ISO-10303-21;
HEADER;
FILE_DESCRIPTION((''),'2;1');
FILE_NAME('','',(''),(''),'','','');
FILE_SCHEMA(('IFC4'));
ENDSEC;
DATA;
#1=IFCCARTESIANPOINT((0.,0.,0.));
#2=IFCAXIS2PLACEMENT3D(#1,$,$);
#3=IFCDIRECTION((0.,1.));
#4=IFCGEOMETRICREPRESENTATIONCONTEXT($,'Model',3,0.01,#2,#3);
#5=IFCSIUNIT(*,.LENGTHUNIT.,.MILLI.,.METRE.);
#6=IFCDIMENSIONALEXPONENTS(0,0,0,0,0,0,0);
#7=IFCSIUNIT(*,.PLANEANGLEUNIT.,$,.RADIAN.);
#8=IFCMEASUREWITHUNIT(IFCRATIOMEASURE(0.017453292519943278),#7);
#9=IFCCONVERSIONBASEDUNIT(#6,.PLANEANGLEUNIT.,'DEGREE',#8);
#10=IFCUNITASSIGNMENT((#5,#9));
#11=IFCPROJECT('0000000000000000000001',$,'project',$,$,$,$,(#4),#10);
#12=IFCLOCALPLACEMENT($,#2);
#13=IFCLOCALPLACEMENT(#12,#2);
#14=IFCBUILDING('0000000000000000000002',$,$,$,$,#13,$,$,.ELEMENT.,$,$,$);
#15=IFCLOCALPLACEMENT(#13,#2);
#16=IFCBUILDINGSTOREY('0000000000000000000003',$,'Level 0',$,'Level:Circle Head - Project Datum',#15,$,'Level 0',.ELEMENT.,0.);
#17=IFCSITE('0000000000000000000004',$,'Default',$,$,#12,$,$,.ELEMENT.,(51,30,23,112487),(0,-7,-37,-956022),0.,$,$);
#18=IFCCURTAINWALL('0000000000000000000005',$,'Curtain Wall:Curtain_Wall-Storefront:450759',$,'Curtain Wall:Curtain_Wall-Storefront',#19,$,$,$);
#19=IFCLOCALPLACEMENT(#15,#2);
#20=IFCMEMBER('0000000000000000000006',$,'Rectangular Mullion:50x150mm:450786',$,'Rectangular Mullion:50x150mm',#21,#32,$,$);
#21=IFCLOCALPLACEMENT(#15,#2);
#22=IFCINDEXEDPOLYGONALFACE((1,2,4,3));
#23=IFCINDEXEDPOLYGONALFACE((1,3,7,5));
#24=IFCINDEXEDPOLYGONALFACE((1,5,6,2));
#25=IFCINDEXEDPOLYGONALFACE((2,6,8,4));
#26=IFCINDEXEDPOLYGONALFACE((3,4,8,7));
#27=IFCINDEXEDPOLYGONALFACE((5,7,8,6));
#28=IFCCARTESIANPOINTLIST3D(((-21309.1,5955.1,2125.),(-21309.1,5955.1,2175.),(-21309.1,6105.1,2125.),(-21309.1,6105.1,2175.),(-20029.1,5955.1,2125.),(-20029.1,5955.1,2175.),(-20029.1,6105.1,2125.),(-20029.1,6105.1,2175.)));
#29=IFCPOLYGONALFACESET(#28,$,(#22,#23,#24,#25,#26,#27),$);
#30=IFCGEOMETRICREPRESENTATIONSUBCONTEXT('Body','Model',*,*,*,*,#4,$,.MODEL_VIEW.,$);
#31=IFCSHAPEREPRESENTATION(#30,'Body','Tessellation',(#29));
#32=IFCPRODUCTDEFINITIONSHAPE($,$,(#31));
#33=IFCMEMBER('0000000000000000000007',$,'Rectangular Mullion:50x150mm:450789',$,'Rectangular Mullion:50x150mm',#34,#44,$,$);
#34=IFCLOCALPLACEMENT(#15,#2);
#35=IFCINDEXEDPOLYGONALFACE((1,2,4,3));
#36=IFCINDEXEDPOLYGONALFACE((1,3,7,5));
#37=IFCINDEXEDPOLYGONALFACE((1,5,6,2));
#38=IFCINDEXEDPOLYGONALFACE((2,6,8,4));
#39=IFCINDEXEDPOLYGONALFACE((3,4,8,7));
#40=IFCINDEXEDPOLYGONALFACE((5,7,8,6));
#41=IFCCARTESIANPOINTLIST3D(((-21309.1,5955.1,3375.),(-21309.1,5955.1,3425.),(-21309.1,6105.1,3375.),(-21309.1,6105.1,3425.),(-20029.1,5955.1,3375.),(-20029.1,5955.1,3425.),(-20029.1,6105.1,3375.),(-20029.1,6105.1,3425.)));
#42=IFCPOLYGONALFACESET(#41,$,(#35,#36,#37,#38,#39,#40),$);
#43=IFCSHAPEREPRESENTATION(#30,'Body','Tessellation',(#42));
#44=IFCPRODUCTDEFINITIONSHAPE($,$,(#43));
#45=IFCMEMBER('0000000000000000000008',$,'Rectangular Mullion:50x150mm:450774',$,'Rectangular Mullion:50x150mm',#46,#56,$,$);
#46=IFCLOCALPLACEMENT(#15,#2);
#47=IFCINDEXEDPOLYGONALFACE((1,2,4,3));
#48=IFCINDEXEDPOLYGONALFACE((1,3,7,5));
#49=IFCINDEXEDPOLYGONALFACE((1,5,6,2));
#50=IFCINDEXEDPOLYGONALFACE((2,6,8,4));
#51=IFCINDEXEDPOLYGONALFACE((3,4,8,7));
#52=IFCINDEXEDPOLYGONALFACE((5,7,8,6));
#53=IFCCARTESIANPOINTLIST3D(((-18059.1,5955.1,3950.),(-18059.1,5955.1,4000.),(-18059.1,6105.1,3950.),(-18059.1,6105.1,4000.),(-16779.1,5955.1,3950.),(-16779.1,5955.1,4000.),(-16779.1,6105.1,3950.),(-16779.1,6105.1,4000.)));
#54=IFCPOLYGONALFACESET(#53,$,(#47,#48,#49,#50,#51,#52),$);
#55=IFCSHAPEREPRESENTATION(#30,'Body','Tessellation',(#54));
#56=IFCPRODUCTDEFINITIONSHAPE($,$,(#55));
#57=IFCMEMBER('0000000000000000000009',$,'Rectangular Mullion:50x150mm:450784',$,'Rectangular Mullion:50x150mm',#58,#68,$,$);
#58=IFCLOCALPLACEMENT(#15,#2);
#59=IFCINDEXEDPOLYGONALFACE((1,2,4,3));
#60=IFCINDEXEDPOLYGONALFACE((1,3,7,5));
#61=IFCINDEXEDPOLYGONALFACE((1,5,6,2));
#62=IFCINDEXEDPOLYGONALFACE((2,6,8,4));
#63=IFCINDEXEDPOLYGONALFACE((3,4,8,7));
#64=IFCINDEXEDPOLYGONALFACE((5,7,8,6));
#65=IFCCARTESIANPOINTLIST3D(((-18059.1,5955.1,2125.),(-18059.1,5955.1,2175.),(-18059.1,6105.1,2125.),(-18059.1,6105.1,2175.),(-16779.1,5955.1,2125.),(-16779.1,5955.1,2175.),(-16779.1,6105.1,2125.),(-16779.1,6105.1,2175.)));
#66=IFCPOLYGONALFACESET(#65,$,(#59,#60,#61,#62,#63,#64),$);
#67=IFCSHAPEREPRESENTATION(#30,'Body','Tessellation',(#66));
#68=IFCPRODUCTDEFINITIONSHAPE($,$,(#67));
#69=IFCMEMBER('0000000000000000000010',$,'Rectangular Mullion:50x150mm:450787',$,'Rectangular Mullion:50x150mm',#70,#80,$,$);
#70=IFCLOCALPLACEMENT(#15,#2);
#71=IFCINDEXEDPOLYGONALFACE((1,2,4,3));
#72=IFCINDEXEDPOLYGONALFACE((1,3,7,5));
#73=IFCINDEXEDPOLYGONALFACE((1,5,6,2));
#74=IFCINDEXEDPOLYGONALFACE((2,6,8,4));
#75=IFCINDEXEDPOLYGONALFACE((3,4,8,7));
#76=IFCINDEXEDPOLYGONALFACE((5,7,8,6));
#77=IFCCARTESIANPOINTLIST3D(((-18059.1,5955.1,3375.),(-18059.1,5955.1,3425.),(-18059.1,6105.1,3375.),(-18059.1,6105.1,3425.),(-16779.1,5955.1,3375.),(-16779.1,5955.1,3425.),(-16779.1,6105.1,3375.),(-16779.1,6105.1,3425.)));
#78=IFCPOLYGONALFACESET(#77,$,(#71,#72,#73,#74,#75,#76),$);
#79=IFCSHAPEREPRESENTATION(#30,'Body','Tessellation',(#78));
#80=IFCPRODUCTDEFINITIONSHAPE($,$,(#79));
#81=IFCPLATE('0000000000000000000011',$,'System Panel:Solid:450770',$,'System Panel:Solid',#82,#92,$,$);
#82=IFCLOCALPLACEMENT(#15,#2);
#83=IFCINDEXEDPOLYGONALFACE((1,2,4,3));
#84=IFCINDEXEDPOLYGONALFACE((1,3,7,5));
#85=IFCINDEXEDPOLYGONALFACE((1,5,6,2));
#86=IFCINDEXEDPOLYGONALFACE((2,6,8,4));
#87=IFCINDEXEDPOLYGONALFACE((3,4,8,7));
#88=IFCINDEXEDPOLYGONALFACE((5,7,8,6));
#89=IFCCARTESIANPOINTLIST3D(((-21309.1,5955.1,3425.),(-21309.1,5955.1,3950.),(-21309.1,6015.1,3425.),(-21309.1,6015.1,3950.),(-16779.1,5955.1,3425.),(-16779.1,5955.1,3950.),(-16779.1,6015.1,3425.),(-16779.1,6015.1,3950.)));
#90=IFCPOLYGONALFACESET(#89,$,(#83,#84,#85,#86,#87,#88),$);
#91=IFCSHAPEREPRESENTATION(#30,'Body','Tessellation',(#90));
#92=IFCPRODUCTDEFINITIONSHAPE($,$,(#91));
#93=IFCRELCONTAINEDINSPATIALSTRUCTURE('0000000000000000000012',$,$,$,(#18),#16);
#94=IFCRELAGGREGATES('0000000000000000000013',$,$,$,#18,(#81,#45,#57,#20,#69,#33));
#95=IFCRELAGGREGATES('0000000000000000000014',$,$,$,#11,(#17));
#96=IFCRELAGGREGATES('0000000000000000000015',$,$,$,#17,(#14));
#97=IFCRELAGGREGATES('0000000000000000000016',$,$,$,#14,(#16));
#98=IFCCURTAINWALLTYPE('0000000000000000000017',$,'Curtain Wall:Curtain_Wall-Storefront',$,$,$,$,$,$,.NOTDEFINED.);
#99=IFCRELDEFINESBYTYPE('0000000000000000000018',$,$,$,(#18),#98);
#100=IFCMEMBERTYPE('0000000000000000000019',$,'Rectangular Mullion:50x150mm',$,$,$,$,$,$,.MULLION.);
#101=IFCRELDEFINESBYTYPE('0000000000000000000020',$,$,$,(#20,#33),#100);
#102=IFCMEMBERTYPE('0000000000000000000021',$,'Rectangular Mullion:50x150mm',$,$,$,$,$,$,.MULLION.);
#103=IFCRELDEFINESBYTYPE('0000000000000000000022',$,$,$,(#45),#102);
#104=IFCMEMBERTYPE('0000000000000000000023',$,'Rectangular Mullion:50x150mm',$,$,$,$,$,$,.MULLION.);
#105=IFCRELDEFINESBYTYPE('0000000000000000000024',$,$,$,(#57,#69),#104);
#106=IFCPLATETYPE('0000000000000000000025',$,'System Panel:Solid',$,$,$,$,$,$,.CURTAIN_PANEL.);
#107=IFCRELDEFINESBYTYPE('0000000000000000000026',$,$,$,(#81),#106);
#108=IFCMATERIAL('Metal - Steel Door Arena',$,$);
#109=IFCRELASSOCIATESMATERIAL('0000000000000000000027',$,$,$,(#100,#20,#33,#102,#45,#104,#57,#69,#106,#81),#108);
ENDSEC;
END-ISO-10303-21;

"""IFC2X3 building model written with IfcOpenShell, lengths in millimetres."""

from ifc_helpers import new_model, entity, si_unit, converted_unit, direction, frame, frame_2d, origin, origin_2d_with_axis, place, context, subcontext, project, spatial, rectangle, extrude, source, transform, mapped, material, type_object, type_shapes, element, aggregate, save


model = new_model("IFC2X3")

# Units and contexts
model_context = context("Model", 3, precision=0.01, world=origin(), true_north=direction((0.0, 1.0)))
body_context = subcontext(model_context, "Body", "Model", "MODEL_VIEW")
ifc_project = project(units=[si_unit("LENGTHUNIT", "METRE", prefix="MILLI"), converted_unit("PLANEANGLEUNIT", "DEGREE", entity("IfcRatioMeasure", 0.017453292519943278), si_unit("PLANEANGLEUNIT", "RADIAN"), dimensions=[0, 0, 0, 0, 0, 0, 0])], contexts=[model_context])

# Site, building, storey
site_placement = place(None, origin())
site = spatial("IfcSite", under=ifc_project, at=site_placement, Name="Default", CompositionType="ELEMENT", RefLatitude=(51, 30, 23, 112487), RefLongitude=(0, -7, -37, -956022), RefElevation=0.0)
building_placement = place(site_placement, origin())
building = spatial("IfcBuilding", under=site, at=building_placement, CompositionType="ELEMENT")
storey_placement = place(building_placement, origin())
storey = spatial("IfcBuildingStorey", under=building, at=storey_placement, Name="Level 0", ObjectType="Level:Circle Head - Project Datum", LongName="Level 0", CompositionType="ELEMENT", Elevation=0.0)

# Curtain wall, members, plate
curtain_wall_type = type_object("IfcCurtainWallType", Name="Curtain Wall:Curtain_Wall-Storefront", PredefinedType="NOTDEFINED")
curtain_wall_placement = place(storey_placement, origin())
curtain_wall = element("IfcCurtainWall", 1, at=curtain_wall_placement, inside=storey, type_object=curtain_wall_type, Name="Curtain Wall:Curtain_Wall-Storefront:450759", ObjectType="Curtain Wall:Curtain_Wall-Storefront")
ifc_material_1 = material(Name="Metal - Steel Door Arena")
member_type_1 = type_object("IfcMemberType", Name="Rectangular Mullion:50x150mm", PredefinedType="MULLION", material=ifc_material_1)
shared_shape_1 = source(origin(), body_context, "Body", "SweptSolid", [
    extrude(rectangle(XDim=150.0, YDim=50.0, at=origin_2d_with_axis()), frame((0.0, 0.0, -1280.0), z_axis=(0.0, 0.0, 1.0), x_axis=(0.0, -1.0, 0.0)), (0.0, 0.0, 1.0), 1280.0),
])
type_shapes(member_type_1, [shared_shape_1])
member_1_placement = place(curtain_wall_placement, frame((-21309.1, 6030.1, 2150.0), z_axis=(-1.0, 0.0, 0.0), x_axis=(0.0, 0.0, 1.0)))
member_1 = element("IfcMember", 2, at=member_1_placement, type_object=member_type_1, material=ifc_material_1, Name="Rectangular Mullion:50x150mm:450786", ObjectType="Rectangular Mullion:50x150mm", context=body_context, shape_type="MappedRepresentation", body=[
    mapped(shared_shape_1, transform((0.0, 0.0, 0.0), scale=1.0)),
])
member_2_placement = place(curtain_wall_placement, frame((-21309.1, 6030.1, 3400.0), z_axis=(-1.0, 0.0, 0.0), x_axis=(0.0, 0.0, 1.0)))
member_2 = element("IfcMember", 3, at=member_2_placement, type_object=member_type_1, material=ifc_material_1, Name="Rectangular Mullion:50x150mm:450789", ObjectType="Rectangular Mullion:50x150mm", context=body_context, shape_type="MappedRepresentation", body=[
    mapped(shared_shape_1, transform((0.0, 0.0, 0.0), scale=1.0)),
])
member_type_2 = type_object("IfcMemberType", Name="Rectangular Mullion:50x150mm", PredefinedType="MULLION", material=ifc_material_1)
shared_shape_2 = source(origin(), body_context, "Body", "SweptSolid", [
    extrude(rectangle(XDim=150.0, YDim=50.0, at=origin_2d_with_axis()), frame((-25.0, 0.0, -1280.0), z_axis=(0.0, 0.0, 1.0), x_axis=(0.0, -1.0, 0.0)), (0.0, 0.0, 1.0), 1280.0),
])
type_shapes(member_type_2, [shared_shape_2])
member_3_placement = place(curtain_wall_placement, frame((-18059.1, 6030.1, 4000.0), z_axis=(-1.0, 0.0, 0.0), x_axis=(0.0, 0.0, 1.0)))
member_3 = element("IfcMember", 4, at=member_3_placement, type_object=member_type_2, material=ifc_material_1, Name="Rectangular Mullion:50x150mm:450774", ObjectType="Rectangular Mullion:50x150mm", context=body_context, shape_type="MappedRepresentation", body=[
    mapped(shared_shape_2, transform((0.0, 0.0, 0.0), scale=1.0)),
])
member_type_3 = type_object("IfcMemberType", Name="Rectangular Mullion:50x150mm", PredefinedType="MULLION", material=ifc_material_1)
shared_shape_3 = source(origin(), body_context, "Body", "SweptSolid", [
    extrude(rectangle(XDim=150.0, YDim=50.0, at=origin_2d_with_axis()), frame((0.0, 0.0, -1280.0), z_axis=(0.0, 0.0, 1.0), x_axis=(0.0, -1.0, 0.0)), (0.0, 0.0, 1.0), 1280.0),
])
type_shapes(member_type_3, [shared_shape_3])
member_4_placement = place(curtain_wall_placement, frame((-18059.1, 6030.1, 2150.0), z_axis=(-1.0, 0.0, 0.0), x_axis=(0.0, 0.0, 1.0)))
member_4 = element("IfcMember", 5, at=member_4_placement, type_object=member_type_3, material=ifc_material_1, Name="Rectangular Mullion:50x150mm:450784", ObjectType="Rectangular Mullion:50x150mm", context=body_context, shape_type="MappedRepresentation", body=[
    mapped(shared_shape_3, transform((0.0, 0.0, 0.0), scale=1.0)),
])
member_5_placement = place(curtain_wall_placement, frame((-18059.1, 6030.1, 3400.0), z_axis=(-1.0, 0.0, 0.0), x_axis=(0.0, 0.0, 1.0)))
member_5 = element("IfcMember", 6, at=member_5_placement, type_object=member_type_3, material=ifc_material_1, Name="Rectangular Mullion:50x150mm:450787", ObjectType="Rectangular Mullion:50x150mm", context=body_context, shape_type="MappedRepresentation", body=[
    mapped(shared_shape_3, transform((0.0, 0.0, 0.0), scale=1.0)),
])
plate_type_1 = type_object("IfcPlateType", Name="System Panel:Solid", PredefinedType="CURTAIN_PANEL", material=ifc_material_1)
shared_shape_4 = source(origin(), body_context, "Body", "SweptSolid", [
    extrude(rectangle(XDim=525.0, YDim=4530.0, at=frame_2d((0.0, 0.0), x_axis=(1.0, 0.0))), frame((0.0, 15.0, 262.5), z_axis=(0.0, 1.0, 0.0), x_axis=(0.0, 0.0, 1.0)), (0.0, 0.0, 1.0), 60.0),
])
type_shapes(plate_type_1, [shared_shape_4])
plate_1_placement = place(curtain_wall_placement, frame((-19044.1, 6030.1, 3425.0), z_axis=(0.0, 0.0, 1.0), x_axis=(-1.0, 0.0, 0.0)))
plate_1 = element("IfcPlate", 7, at=plate_1_placement, type_object=plate_type_1, material=ifc_material_1, Name="System Panel:Solid:450770", ObjectType="System Panel:Solid", context=body_context, shape_type="MappedRepresentation", body=[
    mapped(shared_shape_4, transform((0.0, 0.0, 0.0), scale=1.0)),
])
aggregate(curtain_wall, [plate_1, member_3, member_4, member_1, member_5, member_2])

save(model, "model.ifc")
